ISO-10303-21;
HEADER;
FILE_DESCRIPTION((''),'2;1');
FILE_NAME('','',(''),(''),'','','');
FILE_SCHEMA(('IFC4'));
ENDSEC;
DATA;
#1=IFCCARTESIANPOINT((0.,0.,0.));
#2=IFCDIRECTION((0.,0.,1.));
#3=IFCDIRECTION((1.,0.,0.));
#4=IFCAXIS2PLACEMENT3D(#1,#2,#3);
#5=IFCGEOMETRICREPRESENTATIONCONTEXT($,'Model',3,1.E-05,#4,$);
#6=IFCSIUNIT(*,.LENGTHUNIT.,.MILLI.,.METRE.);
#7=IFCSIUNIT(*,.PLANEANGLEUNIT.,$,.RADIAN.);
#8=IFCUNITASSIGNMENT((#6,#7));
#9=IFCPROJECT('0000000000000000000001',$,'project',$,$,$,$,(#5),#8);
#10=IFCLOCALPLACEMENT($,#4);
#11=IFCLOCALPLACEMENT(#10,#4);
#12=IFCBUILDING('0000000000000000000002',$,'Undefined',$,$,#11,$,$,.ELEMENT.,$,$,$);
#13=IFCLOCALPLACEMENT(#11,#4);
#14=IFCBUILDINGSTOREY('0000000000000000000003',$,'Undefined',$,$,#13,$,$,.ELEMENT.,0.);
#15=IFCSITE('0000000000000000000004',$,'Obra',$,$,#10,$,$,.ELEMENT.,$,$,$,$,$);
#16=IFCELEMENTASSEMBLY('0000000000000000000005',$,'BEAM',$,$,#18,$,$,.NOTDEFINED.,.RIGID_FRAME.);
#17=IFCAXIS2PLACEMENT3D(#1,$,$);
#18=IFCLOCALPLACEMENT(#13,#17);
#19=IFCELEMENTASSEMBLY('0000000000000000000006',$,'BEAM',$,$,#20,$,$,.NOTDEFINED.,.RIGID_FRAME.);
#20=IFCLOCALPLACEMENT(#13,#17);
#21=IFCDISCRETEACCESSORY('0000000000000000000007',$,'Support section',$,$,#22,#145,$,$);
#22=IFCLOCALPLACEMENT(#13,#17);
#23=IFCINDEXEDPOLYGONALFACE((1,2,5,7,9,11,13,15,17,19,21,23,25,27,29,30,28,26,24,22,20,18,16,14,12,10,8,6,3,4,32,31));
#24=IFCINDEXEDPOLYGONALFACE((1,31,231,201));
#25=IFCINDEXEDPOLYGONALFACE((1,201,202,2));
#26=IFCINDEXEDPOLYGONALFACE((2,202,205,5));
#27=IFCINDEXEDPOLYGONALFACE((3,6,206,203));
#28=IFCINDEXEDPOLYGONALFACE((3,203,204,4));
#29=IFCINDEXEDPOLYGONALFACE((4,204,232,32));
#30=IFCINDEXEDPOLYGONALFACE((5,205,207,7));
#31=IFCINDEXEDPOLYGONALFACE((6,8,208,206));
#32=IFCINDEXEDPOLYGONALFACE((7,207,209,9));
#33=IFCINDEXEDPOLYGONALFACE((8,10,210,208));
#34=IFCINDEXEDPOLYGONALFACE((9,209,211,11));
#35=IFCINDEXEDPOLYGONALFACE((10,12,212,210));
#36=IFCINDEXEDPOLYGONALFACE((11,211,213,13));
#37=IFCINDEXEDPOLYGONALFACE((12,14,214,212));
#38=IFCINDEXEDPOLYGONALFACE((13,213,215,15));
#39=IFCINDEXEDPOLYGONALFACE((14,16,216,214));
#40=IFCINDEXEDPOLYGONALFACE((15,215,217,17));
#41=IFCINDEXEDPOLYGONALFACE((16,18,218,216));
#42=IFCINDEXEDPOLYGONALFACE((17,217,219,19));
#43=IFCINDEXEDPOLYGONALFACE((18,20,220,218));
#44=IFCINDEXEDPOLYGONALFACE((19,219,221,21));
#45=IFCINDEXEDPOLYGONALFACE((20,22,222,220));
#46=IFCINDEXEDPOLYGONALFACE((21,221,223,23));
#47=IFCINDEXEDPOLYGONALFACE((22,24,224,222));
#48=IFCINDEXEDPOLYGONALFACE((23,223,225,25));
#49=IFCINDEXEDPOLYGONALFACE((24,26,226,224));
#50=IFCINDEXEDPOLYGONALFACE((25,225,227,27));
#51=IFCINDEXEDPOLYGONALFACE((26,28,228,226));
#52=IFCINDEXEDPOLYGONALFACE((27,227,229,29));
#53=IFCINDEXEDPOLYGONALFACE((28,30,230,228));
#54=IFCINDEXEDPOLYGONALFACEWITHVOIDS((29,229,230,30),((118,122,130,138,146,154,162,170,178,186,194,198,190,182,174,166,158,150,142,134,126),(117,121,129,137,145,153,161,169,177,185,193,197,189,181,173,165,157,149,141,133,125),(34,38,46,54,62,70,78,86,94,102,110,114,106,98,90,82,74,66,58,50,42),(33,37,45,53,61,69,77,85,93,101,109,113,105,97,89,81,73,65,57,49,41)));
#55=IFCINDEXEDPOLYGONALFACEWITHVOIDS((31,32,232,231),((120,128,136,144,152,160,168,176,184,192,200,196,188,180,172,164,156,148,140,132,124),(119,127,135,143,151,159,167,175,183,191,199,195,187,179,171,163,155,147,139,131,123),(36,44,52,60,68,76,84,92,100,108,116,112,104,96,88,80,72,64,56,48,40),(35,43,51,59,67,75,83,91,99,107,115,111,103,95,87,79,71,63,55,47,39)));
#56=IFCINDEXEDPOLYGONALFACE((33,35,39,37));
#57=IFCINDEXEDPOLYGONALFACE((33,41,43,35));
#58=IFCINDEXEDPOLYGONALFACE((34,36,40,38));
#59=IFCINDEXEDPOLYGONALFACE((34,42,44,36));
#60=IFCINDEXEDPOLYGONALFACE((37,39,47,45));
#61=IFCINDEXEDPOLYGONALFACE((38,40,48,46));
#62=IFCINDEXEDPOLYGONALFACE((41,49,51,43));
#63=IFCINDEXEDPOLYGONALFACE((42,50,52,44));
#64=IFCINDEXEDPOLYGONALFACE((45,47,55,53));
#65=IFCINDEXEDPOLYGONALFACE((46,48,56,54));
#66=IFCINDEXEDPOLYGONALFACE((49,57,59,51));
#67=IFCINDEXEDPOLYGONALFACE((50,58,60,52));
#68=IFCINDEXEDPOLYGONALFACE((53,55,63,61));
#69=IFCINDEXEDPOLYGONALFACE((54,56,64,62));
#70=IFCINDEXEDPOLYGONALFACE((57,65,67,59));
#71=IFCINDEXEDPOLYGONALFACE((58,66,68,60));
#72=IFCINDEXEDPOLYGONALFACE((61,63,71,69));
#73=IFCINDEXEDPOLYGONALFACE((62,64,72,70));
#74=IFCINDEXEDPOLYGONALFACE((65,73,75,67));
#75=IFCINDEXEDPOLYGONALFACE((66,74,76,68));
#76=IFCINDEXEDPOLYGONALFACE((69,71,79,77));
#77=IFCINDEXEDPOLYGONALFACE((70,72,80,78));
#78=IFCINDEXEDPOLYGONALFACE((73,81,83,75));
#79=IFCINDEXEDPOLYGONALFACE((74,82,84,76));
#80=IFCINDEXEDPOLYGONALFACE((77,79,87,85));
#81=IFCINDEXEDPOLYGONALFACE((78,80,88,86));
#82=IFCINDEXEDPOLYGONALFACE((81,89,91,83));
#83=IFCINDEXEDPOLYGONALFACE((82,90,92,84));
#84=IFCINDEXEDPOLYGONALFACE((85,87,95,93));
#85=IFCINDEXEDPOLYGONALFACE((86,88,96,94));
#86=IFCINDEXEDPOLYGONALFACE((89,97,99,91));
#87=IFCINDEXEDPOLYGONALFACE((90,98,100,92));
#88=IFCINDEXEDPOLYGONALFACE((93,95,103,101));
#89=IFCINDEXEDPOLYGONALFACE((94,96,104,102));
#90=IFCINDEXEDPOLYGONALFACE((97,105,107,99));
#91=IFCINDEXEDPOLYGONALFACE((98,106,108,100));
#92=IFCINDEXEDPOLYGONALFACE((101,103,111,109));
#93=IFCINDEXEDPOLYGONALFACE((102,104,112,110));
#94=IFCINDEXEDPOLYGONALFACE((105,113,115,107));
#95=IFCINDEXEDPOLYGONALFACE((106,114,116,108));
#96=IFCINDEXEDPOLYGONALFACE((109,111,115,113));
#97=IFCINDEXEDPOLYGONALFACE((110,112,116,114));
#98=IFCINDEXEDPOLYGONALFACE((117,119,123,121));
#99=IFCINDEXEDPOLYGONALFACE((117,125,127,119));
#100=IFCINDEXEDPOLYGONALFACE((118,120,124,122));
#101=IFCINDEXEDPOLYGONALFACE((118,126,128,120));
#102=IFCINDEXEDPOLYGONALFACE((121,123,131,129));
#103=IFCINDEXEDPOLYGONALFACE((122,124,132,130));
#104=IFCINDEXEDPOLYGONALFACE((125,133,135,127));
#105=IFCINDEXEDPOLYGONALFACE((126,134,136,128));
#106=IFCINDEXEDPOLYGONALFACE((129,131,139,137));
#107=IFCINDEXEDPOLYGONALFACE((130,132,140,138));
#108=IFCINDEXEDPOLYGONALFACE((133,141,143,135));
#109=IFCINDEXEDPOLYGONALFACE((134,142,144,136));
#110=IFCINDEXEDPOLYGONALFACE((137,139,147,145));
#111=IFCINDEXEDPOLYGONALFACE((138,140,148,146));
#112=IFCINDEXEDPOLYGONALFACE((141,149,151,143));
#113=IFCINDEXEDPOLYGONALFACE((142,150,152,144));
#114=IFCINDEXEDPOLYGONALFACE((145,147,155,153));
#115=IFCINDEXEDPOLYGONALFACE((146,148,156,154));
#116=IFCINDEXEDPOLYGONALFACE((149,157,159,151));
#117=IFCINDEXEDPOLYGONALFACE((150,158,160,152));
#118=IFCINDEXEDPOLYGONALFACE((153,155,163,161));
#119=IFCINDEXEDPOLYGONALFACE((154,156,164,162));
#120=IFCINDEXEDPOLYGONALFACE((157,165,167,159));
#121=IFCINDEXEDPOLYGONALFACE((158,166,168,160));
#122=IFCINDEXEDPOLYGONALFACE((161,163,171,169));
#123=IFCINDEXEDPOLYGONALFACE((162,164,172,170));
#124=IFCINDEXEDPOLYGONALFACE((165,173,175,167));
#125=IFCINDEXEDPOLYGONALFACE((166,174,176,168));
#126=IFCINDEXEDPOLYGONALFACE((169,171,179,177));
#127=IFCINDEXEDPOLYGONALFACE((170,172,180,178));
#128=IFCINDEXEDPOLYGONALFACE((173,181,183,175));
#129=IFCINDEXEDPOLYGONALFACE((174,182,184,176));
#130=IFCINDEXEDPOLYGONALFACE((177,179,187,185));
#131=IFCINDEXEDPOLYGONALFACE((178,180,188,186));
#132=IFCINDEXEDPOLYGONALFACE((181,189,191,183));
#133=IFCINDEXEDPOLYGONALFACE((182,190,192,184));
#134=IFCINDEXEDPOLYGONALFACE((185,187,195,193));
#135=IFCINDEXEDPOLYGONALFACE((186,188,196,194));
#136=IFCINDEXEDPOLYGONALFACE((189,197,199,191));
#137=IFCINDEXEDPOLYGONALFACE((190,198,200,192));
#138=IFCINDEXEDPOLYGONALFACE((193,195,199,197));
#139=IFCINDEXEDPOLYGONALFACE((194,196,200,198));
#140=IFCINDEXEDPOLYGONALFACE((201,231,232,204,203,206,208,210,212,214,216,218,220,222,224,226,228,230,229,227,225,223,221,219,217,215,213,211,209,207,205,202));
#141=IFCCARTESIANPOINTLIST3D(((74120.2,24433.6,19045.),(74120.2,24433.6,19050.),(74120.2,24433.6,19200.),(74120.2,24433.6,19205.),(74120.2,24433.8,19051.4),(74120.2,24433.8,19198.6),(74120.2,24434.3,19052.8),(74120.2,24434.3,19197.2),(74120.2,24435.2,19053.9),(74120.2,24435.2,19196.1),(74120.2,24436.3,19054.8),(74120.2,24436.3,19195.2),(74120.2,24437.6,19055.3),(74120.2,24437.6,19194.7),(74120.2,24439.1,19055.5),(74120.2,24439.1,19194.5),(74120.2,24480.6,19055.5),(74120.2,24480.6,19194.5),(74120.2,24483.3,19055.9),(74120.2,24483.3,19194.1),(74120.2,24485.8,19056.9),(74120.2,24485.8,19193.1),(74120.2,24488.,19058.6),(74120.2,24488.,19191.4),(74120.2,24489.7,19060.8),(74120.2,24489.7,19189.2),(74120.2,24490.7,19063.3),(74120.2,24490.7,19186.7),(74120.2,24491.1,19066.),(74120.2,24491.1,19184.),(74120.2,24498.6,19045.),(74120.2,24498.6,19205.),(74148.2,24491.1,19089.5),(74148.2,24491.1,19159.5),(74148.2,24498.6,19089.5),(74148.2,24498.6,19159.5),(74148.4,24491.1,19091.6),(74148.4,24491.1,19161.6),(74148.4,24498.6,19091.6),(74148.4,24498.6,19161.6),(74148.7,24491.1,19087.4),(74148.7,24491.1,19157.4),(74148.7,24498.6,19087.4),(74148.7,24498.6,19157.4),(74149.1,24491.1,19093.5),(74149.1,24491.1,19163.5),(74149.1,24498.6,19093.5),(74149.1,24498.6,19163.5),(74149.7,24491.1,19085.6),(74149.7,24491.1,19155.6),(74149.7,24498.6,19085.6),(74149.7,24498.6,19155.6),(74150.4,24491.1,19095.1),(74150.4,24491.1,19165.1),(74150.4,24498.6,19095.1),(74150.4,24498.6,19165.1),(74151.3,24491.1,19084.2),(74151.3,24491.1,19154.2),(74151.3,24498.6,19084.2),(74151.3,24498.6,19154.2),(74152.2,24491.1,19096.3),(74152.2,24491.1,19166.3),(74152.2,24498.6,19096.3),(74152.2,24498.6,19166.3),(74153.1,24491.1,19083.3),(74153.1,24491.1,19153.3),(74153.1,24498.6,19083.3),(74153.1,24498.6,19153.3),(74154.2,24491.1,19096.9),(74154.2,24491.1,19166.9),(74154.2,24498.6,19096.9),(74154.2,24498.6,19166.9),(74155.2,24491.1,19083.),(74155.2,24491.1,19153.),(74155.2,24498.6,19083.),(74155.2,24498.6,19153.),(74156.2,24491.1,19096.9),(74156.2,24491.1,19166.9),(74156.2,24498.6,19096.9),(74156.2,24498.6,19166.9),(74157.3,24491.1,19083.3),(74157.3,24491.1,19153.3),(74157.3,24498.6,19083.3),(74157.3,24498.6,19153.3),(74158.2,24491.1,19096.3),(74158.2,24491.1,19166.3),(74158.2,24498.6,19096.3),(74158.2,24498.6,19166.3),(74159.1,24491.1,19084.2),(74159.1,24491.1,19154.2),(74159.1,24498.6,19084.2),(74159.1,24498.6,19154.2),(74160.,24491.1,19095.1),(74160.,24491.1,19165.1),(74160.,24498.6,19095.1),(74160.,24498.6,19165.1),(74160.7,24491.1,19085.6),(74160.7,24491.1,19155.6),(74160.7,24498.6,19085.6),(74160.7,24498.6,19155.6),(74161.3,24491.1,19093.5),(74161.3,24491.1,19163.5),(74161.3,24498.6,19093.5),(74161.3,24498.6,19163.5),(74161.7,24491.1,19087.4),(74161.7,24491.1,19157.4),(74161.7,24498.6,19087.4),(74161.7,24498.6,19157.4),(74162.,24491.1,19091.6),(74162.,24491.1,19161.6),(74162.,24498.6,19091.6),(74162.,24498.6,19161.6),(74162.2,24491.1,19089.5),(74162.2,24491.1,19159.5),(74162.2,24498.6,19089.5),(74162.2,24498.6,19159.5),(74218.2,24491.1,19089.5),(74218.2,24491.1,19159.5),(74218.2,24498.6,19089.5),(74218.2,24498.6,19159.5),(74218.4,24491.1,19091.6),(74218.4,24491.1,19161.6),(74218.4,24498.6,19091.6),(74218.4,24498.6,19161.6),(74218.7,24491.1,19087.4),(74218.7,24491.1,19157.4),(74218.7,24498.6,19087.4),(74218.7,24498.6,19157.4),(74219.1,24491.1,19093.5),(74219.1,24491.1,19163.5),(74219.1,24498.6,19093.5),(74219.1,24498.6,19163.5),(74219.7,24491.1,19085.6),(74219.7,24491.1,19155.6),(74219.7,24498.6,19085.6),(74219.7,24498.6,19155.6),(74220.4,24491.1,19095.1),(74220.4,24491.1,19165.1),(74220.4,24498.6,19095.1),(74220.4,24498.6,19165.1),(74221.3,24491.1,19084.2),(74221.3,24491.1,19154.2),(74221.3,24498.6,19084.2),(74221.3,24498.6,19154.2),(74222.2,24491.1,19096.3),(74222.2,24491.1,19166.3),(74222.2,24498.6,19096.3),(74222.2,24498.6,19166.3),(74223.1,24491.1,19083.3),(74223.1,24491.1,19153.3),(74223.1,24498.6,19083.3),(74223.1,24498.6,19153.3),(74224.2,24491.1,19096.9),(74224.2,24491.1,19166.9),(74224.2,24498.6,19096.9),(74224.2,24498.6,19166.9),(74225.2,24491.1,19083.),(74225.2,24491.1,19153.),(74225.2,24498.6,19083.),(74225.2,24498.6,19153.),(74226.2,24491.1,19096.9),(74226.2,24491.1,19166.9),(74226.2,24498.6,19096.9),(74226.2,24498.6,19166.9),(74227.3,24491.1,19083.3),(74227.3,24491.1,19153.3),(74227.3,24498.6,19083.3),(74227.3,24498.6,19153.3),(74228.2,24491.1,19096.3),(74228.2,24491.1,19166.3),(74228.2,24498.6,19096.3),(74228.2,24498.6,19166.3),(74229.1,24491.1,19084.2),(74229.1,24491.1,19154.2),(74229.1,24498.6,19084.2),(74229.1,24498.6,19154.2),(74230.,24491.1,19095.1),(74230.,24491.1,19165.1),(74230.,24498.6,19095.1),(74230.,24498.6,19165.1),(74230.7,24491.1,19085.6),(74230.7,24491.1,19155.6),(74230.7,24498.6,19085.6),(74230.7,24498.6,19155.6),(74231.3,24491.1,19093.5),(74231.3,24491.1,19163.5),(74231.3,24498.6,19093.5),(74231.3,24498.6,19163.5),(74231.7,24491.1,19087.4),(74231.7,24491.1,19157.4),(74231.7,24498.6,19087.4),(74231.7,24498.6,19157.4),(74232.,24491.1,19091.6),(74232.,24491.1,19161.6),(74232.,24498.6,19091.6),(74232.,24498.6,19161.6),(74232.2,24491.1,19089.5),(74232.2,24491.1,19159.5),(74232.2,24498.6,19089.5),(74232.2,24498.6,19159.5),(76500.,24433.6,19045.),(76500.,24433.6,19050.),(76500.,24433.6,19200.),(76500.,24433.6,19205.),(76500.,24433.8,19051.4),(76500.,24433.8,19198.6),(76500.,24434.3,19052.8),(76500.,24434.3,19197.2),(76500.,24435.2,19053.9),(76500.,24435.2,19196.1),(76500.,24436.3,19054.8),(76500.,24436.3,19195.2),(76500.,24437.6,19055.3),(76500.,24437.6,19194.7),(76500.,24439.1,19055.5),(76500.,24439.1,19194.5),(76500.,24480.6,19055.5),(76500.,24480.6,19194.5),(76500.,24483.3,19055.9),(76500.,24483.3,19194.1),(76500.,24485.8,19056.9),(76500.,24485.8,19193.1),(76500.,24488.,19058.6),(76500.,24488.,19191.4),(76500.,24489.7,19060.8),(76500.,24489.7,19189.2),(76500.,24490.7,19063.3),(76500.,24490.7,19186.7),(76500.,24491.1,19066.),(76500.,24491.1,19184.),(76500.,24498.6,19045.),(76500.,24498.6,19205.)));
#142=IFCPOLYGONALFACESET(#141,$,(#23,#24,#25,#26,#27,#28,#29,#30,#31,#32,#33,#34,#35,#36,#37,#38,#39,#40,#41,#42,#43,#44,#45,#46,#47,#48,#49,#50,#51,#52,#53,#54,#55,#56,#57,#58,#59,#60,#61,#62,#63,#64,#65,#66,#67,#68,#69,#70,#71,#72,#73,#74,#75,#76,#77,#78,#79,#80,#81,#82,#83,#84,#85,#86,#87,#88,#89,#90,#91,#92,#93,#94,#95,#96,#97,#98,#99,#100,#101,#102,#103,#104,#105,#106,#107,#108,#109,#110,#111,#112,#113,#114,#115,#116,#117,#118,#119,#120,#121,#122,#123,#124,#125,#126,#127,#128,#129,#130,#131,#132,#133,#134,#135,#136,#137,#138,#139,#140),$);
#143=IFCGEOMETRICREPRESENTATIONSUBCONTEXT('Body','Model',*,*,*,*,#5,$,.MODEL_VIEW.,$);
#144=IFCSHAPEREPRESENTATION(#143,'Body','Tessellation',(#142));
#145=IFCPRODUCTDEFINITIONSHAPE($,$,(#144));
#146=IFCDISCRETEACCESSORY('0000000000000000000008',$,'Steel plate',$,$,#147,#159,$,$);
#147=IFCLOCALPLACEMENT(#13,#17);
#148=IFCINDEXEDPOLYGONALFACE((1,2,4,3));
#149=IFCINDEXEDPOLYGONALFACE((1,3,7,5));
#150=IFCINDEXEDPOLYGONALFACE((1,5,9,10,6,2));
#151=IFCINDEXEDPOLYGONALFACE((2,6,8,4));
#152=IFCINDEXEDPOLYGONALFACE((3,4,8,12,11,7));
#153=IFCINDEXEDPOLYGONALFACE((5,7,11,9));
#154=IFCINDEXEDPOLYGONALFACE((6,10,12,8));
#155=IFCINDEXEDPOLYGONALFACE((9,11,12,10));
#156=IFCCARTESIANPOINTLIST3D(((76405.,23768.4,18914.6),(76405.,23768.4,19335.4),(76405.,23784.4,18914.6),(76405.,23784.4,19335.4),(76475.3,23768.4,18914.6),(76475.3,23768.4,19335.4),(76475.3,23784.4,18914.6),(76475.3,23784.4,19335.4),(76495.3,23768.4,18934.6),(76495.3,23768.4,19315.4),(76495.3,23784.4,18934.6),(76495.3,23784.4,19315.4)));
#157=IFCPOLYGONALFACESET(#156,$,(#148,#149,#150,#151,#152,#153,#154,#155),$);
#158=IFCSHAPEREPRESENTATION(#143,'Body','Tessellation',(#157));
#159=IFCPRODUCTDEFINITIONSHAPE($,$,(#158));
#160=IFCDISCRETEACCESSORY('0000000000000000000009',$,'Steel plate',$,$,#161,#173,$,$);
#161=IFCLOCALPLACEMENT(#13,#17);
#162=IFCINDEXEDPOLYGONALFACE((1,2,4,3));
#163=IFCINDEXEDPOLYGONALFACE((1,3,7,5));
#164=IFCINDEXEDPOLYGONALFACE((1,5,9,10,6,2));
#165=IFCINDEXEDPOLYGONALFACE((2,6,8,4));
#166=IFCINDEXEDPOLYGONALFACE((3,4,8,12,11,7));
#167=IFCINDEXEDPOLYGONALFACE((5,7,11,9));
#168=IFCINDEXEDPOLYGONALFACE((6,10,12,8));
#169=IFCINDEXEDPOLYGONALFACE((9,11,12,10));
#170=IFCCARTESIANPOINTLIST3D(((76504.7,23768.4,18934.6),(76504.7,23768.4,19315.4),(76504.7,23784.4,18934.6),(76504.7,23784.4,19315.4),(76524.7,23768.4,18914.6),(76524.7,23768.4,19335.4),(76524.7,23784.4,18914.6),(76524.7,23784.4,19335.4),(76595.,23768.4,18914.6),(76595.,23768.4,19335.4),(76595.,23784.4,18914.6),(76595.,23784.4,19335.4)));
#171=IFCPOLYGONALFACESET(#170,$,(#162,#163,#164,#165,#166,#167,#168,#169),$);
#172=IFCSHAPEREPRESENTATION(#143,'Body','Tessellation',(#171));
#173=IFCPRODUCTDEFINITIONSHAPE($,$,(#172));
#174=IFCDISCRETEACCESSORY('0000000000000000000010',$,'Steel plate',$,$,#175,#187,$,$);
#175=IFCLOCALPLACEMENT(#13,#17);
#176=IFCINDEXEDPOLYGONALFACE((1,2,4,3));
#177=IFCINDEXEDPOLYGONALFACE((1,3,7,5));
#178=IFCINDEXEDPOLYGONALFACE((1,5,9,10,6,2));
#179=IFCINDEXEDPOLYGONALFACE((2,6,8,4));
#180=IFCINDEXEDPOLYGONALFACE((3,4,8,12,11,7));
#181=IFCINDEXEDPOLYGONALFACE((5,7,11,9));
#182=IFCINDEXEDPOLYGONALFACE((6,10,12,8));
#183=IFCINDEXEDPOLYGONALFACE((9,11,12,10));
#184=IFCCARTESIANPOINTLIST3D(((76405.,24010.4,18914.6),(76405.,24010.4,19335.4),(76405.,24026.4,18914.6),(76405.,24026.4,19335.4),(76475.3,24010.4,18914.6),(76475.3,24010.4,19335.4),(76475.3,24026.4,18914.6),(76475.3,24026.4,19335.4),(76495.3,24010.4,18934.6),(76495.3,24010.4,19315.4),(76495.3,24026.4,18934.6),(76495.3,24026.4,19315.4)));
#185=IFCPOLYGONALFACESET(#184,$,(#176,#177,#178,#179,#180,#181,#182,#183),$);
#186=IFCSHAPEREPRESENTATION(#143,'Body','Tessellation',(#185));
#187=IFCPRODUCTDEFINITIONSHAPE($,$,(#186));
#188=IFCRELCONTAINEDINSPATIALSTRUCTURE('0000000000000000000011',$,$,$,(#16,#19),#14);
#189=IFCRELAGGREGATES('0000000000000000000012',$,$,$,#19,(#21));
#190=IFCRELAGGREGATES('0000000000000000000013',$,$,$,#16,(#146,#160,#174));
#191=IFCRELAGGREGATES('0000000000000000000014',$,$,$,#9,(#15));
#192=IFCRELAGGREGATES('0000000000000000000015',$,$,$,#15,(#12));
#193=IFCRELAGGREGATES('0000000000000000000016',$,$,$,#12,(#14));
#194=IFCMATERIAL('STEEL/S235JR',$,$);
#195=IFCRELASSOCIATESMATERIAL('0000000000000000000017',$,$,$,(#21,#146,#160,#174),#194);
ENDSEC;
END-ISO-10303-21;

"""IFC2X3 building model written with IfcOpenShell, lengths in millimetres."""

from ifc_helpers import new_model, si_unit, frame, origin_with_axes, origin_2d_with_axis, place, context, subcontext, project, spatial, polyline, circle, u_section, outline, extrude, clip, halfspace, source, transform, mapped, material, element, aggregate, save


model = new_model("IFC2X3")

# Units and contexts
model_context = context("Model", 3, precision=1e-05, world=origin_with_axes())
body_context = subcontext(model_context, "Body", "Model", "MODEL_VIEW")
ifc_project = project(units=[si_unit("LENGTHUNIT", "METRE", prefix="MILLI"), si_unit("PLANEANGLEUNIT", "RADIAN")], contexts=[model_context])

# Site, building, storey
site_placement = place(None, origin_with_axes())
site = spatial("IfcSite", under=ifc_project, at=site_placement, Name="Obra", CompositionType="ELEMENT")
building_placement = place(site_placement, origin_with_axes())
building = spatial("IfcBuilding", under=site, at=building_placement, Name="Undefined", CompositionType="ELEMENT")
storey_placement = place(building_placement, origin_with_axes())
storey = spatial("IfcBuildingStorey", under=building, at=storey_placement, Name="Undefined", CompositionType="ELEMENT", Elevation=0.0)

# Shared definitions
ifc_material_1 = material(Name="STEEL/S235JR")

# Element assembly
assembly_1_placement = place(storey_placement, origin_with_axes())
assembly_1 = element("IfcElementAssembly", 1, at=assembly_1_placement, inside=storey, Name="BEAM", AssemblyPlace="NOTDEFINED", PredefinedType="RIGID_FRAME")

# Element assembly, discrete accessory, opening
assembly_2_placement = place(storey_placement, origin_with_axes())
assembly_2 = element("IfcElementAssembly", 2, at=assembly_2_placement, inside=storey, Name="BEAM", AssemblyPlace="NOTDEFINED", PredefinedType="RIGID_FRAME")
shared_shape_1 = source(origin_with_axes(), body_context, "Body", "SweptSolid", [
    extrude(circle(Radius=7.0, at=origin_2d_with_axis()), frame((0.0, -3.8, 0.0), z_axis=(0.0, 1.0, 0.0), x_axis=(1.0, 0.0, 0.0)), (0.0, 0.0, 1.0), 7.7),
])
discrete_accessory_1_placement = place(assembly_2_placement, frame((74115.2, 24466.1, 19125.0), z_axis=(0.0, 0.0, 1.0), x_axis=(1.0, 0.0, 0.0)))
discrete_accessory_1 = element("IfcDiscreteAccessory", 3, at=discrete_accessory_1_placement, material=ifc_material_1, Name="Support section", context=body_context, shape_type="Clipping", body=[
    clip(extrude(u_section(Depth=160.0, FlangeWidth=65.0, WebThickness=7.5, FlangeThickness=10.5, FilletRadius=10.5, EdgeRadius=5.5, at=origin_2d_with_axis()), frame((2384.8, 0.0, 0.0), z_axis=(-1.0, 0.0, 0.0), x_axis=(0.0, -1.0, 0.0)), (0.0, 0.0, 1.0), 2379.8), halfspace(frame((5.0, 0.0, 166.3), z_axis=(-1.0, 0.0, 0.0), x_axis=(0.0, -1.0, 0.0)), False)),
])
opening_1_placement = place(assembly_2_placement, frame((74155.2, 24494.8, 19160.0), z_axis=(1.0, 0.0, 0.0), x_axis=(0.0, 0.0, -1.0)))
element("IfcOpeningElement", 4, at=opening_1_placement, cuts=discrete_accessory_1, ObjectType="Opening", context=body_context, shape_type="MappedRepresentation", body=[
    mapped(shared_shape_1, transform((0.0, 0.0, 0.0))),
    mapped(shared_shape_1, transform((0.0, 0.0, 70.0))),
    mapped(shared_shape_1, transform((70.0, 0.0, 0.0))),
    mapped(shared_shape_1, transform((70.0, 0.0, 70.0))),
])
aggregate(assembly_2, [discrete_accessory_1])

# Discrete accessories
discrete_accessory_2_placement = place(assembly_1_placement, frame((76405.0, 23776.4, 19335.4), z_axis=(-0.000004, 1.0, 0.0), x_axis=(1.0, 0.000003, 0.0)))
discrete_accessory_2 = element("IfcDiscreteAccessory", 5, at=discrete_accessory_2_placement, material=ifc_material_1, Name="Steel plate", context=body_context, shape_type="SweptSolid", body=[
    extrude(outline(polyline([(0.0, 0.0), (70.3, 0.0), (90.3, 20.0), (90.3, 400.8), (70.3, 420.8), (0.0, 420.8), (0.0, 0.0)])), frame((0.0, 0.0, -8.0), z_axis=(0.0, 0.0, 1.0), x_axis=(1.0, 0.0, 0.0)), (0.0, 0.0, 1.0), 16.0),
])
discrete_accessory_3_placement = place(assembly_1_placement, frame((76595.0, 23776.4, 19335.4), z_axis=(0.000003, -1.0, 0.0), x_axis=(-1.0, -0.000004, 0.0)))
discrete_accessory_3 = element("IfcDiscreteAccessory", 6, at=discrete_accessory_3_placement, material=ifc_material_1, Name="Steel plate", context=body_context, shape_type="SweptSolid", body=[
    extrude(outline(polyline([(0.0, 0.0), (70.3, 0.0), (90.3, 20.0), (90.3, 400.8), (70.3, 420.8), (0.0, 420.8), (0.0, 0.0)])), frame((0.0, 0.0, -8.0), z_axis=(0.0, 0.0, 1.0), x_axis=(1.0, 0.0, 0.0)), (0.0, 0.0, 1.0), 16.0),
])
discrete_accessory_4_placement = place(assembly_1_placement, frame((76405.0, 24018.4, 19335.4), z_axis=(-0.000004, 1.0, 0.0), x_axis=(1.0, 0.000003, 0.0)))
discrete_accessory_4 = element("IfcDiscreteAccessory", 7, at=discrete_accessory_4_placement, material=ifc_material_1, Name="Steel plate", context=body_context, shape_type="SweptSolid", body=[
    extrude(outline(polyline([(0.0, 0.0), (70.3, 0.0), (90.3, 20.0), (90.3, 400.8), (70.3, 420.8), (0.0, 420.8), (0.0, 0.0)])), frame((0.0, 0.0, -8.0), z_axis=(0.0, 0.0, 1.0), x_axis=(1.0, 0.0, 0.0)), (0.0, 0.0, 1.0), 16.0),
])
aggregate(assembly_1, [discrete_accessory_2, discrete_accessory_3, discrete_accessory_4])

save(model, "model.ifc")
